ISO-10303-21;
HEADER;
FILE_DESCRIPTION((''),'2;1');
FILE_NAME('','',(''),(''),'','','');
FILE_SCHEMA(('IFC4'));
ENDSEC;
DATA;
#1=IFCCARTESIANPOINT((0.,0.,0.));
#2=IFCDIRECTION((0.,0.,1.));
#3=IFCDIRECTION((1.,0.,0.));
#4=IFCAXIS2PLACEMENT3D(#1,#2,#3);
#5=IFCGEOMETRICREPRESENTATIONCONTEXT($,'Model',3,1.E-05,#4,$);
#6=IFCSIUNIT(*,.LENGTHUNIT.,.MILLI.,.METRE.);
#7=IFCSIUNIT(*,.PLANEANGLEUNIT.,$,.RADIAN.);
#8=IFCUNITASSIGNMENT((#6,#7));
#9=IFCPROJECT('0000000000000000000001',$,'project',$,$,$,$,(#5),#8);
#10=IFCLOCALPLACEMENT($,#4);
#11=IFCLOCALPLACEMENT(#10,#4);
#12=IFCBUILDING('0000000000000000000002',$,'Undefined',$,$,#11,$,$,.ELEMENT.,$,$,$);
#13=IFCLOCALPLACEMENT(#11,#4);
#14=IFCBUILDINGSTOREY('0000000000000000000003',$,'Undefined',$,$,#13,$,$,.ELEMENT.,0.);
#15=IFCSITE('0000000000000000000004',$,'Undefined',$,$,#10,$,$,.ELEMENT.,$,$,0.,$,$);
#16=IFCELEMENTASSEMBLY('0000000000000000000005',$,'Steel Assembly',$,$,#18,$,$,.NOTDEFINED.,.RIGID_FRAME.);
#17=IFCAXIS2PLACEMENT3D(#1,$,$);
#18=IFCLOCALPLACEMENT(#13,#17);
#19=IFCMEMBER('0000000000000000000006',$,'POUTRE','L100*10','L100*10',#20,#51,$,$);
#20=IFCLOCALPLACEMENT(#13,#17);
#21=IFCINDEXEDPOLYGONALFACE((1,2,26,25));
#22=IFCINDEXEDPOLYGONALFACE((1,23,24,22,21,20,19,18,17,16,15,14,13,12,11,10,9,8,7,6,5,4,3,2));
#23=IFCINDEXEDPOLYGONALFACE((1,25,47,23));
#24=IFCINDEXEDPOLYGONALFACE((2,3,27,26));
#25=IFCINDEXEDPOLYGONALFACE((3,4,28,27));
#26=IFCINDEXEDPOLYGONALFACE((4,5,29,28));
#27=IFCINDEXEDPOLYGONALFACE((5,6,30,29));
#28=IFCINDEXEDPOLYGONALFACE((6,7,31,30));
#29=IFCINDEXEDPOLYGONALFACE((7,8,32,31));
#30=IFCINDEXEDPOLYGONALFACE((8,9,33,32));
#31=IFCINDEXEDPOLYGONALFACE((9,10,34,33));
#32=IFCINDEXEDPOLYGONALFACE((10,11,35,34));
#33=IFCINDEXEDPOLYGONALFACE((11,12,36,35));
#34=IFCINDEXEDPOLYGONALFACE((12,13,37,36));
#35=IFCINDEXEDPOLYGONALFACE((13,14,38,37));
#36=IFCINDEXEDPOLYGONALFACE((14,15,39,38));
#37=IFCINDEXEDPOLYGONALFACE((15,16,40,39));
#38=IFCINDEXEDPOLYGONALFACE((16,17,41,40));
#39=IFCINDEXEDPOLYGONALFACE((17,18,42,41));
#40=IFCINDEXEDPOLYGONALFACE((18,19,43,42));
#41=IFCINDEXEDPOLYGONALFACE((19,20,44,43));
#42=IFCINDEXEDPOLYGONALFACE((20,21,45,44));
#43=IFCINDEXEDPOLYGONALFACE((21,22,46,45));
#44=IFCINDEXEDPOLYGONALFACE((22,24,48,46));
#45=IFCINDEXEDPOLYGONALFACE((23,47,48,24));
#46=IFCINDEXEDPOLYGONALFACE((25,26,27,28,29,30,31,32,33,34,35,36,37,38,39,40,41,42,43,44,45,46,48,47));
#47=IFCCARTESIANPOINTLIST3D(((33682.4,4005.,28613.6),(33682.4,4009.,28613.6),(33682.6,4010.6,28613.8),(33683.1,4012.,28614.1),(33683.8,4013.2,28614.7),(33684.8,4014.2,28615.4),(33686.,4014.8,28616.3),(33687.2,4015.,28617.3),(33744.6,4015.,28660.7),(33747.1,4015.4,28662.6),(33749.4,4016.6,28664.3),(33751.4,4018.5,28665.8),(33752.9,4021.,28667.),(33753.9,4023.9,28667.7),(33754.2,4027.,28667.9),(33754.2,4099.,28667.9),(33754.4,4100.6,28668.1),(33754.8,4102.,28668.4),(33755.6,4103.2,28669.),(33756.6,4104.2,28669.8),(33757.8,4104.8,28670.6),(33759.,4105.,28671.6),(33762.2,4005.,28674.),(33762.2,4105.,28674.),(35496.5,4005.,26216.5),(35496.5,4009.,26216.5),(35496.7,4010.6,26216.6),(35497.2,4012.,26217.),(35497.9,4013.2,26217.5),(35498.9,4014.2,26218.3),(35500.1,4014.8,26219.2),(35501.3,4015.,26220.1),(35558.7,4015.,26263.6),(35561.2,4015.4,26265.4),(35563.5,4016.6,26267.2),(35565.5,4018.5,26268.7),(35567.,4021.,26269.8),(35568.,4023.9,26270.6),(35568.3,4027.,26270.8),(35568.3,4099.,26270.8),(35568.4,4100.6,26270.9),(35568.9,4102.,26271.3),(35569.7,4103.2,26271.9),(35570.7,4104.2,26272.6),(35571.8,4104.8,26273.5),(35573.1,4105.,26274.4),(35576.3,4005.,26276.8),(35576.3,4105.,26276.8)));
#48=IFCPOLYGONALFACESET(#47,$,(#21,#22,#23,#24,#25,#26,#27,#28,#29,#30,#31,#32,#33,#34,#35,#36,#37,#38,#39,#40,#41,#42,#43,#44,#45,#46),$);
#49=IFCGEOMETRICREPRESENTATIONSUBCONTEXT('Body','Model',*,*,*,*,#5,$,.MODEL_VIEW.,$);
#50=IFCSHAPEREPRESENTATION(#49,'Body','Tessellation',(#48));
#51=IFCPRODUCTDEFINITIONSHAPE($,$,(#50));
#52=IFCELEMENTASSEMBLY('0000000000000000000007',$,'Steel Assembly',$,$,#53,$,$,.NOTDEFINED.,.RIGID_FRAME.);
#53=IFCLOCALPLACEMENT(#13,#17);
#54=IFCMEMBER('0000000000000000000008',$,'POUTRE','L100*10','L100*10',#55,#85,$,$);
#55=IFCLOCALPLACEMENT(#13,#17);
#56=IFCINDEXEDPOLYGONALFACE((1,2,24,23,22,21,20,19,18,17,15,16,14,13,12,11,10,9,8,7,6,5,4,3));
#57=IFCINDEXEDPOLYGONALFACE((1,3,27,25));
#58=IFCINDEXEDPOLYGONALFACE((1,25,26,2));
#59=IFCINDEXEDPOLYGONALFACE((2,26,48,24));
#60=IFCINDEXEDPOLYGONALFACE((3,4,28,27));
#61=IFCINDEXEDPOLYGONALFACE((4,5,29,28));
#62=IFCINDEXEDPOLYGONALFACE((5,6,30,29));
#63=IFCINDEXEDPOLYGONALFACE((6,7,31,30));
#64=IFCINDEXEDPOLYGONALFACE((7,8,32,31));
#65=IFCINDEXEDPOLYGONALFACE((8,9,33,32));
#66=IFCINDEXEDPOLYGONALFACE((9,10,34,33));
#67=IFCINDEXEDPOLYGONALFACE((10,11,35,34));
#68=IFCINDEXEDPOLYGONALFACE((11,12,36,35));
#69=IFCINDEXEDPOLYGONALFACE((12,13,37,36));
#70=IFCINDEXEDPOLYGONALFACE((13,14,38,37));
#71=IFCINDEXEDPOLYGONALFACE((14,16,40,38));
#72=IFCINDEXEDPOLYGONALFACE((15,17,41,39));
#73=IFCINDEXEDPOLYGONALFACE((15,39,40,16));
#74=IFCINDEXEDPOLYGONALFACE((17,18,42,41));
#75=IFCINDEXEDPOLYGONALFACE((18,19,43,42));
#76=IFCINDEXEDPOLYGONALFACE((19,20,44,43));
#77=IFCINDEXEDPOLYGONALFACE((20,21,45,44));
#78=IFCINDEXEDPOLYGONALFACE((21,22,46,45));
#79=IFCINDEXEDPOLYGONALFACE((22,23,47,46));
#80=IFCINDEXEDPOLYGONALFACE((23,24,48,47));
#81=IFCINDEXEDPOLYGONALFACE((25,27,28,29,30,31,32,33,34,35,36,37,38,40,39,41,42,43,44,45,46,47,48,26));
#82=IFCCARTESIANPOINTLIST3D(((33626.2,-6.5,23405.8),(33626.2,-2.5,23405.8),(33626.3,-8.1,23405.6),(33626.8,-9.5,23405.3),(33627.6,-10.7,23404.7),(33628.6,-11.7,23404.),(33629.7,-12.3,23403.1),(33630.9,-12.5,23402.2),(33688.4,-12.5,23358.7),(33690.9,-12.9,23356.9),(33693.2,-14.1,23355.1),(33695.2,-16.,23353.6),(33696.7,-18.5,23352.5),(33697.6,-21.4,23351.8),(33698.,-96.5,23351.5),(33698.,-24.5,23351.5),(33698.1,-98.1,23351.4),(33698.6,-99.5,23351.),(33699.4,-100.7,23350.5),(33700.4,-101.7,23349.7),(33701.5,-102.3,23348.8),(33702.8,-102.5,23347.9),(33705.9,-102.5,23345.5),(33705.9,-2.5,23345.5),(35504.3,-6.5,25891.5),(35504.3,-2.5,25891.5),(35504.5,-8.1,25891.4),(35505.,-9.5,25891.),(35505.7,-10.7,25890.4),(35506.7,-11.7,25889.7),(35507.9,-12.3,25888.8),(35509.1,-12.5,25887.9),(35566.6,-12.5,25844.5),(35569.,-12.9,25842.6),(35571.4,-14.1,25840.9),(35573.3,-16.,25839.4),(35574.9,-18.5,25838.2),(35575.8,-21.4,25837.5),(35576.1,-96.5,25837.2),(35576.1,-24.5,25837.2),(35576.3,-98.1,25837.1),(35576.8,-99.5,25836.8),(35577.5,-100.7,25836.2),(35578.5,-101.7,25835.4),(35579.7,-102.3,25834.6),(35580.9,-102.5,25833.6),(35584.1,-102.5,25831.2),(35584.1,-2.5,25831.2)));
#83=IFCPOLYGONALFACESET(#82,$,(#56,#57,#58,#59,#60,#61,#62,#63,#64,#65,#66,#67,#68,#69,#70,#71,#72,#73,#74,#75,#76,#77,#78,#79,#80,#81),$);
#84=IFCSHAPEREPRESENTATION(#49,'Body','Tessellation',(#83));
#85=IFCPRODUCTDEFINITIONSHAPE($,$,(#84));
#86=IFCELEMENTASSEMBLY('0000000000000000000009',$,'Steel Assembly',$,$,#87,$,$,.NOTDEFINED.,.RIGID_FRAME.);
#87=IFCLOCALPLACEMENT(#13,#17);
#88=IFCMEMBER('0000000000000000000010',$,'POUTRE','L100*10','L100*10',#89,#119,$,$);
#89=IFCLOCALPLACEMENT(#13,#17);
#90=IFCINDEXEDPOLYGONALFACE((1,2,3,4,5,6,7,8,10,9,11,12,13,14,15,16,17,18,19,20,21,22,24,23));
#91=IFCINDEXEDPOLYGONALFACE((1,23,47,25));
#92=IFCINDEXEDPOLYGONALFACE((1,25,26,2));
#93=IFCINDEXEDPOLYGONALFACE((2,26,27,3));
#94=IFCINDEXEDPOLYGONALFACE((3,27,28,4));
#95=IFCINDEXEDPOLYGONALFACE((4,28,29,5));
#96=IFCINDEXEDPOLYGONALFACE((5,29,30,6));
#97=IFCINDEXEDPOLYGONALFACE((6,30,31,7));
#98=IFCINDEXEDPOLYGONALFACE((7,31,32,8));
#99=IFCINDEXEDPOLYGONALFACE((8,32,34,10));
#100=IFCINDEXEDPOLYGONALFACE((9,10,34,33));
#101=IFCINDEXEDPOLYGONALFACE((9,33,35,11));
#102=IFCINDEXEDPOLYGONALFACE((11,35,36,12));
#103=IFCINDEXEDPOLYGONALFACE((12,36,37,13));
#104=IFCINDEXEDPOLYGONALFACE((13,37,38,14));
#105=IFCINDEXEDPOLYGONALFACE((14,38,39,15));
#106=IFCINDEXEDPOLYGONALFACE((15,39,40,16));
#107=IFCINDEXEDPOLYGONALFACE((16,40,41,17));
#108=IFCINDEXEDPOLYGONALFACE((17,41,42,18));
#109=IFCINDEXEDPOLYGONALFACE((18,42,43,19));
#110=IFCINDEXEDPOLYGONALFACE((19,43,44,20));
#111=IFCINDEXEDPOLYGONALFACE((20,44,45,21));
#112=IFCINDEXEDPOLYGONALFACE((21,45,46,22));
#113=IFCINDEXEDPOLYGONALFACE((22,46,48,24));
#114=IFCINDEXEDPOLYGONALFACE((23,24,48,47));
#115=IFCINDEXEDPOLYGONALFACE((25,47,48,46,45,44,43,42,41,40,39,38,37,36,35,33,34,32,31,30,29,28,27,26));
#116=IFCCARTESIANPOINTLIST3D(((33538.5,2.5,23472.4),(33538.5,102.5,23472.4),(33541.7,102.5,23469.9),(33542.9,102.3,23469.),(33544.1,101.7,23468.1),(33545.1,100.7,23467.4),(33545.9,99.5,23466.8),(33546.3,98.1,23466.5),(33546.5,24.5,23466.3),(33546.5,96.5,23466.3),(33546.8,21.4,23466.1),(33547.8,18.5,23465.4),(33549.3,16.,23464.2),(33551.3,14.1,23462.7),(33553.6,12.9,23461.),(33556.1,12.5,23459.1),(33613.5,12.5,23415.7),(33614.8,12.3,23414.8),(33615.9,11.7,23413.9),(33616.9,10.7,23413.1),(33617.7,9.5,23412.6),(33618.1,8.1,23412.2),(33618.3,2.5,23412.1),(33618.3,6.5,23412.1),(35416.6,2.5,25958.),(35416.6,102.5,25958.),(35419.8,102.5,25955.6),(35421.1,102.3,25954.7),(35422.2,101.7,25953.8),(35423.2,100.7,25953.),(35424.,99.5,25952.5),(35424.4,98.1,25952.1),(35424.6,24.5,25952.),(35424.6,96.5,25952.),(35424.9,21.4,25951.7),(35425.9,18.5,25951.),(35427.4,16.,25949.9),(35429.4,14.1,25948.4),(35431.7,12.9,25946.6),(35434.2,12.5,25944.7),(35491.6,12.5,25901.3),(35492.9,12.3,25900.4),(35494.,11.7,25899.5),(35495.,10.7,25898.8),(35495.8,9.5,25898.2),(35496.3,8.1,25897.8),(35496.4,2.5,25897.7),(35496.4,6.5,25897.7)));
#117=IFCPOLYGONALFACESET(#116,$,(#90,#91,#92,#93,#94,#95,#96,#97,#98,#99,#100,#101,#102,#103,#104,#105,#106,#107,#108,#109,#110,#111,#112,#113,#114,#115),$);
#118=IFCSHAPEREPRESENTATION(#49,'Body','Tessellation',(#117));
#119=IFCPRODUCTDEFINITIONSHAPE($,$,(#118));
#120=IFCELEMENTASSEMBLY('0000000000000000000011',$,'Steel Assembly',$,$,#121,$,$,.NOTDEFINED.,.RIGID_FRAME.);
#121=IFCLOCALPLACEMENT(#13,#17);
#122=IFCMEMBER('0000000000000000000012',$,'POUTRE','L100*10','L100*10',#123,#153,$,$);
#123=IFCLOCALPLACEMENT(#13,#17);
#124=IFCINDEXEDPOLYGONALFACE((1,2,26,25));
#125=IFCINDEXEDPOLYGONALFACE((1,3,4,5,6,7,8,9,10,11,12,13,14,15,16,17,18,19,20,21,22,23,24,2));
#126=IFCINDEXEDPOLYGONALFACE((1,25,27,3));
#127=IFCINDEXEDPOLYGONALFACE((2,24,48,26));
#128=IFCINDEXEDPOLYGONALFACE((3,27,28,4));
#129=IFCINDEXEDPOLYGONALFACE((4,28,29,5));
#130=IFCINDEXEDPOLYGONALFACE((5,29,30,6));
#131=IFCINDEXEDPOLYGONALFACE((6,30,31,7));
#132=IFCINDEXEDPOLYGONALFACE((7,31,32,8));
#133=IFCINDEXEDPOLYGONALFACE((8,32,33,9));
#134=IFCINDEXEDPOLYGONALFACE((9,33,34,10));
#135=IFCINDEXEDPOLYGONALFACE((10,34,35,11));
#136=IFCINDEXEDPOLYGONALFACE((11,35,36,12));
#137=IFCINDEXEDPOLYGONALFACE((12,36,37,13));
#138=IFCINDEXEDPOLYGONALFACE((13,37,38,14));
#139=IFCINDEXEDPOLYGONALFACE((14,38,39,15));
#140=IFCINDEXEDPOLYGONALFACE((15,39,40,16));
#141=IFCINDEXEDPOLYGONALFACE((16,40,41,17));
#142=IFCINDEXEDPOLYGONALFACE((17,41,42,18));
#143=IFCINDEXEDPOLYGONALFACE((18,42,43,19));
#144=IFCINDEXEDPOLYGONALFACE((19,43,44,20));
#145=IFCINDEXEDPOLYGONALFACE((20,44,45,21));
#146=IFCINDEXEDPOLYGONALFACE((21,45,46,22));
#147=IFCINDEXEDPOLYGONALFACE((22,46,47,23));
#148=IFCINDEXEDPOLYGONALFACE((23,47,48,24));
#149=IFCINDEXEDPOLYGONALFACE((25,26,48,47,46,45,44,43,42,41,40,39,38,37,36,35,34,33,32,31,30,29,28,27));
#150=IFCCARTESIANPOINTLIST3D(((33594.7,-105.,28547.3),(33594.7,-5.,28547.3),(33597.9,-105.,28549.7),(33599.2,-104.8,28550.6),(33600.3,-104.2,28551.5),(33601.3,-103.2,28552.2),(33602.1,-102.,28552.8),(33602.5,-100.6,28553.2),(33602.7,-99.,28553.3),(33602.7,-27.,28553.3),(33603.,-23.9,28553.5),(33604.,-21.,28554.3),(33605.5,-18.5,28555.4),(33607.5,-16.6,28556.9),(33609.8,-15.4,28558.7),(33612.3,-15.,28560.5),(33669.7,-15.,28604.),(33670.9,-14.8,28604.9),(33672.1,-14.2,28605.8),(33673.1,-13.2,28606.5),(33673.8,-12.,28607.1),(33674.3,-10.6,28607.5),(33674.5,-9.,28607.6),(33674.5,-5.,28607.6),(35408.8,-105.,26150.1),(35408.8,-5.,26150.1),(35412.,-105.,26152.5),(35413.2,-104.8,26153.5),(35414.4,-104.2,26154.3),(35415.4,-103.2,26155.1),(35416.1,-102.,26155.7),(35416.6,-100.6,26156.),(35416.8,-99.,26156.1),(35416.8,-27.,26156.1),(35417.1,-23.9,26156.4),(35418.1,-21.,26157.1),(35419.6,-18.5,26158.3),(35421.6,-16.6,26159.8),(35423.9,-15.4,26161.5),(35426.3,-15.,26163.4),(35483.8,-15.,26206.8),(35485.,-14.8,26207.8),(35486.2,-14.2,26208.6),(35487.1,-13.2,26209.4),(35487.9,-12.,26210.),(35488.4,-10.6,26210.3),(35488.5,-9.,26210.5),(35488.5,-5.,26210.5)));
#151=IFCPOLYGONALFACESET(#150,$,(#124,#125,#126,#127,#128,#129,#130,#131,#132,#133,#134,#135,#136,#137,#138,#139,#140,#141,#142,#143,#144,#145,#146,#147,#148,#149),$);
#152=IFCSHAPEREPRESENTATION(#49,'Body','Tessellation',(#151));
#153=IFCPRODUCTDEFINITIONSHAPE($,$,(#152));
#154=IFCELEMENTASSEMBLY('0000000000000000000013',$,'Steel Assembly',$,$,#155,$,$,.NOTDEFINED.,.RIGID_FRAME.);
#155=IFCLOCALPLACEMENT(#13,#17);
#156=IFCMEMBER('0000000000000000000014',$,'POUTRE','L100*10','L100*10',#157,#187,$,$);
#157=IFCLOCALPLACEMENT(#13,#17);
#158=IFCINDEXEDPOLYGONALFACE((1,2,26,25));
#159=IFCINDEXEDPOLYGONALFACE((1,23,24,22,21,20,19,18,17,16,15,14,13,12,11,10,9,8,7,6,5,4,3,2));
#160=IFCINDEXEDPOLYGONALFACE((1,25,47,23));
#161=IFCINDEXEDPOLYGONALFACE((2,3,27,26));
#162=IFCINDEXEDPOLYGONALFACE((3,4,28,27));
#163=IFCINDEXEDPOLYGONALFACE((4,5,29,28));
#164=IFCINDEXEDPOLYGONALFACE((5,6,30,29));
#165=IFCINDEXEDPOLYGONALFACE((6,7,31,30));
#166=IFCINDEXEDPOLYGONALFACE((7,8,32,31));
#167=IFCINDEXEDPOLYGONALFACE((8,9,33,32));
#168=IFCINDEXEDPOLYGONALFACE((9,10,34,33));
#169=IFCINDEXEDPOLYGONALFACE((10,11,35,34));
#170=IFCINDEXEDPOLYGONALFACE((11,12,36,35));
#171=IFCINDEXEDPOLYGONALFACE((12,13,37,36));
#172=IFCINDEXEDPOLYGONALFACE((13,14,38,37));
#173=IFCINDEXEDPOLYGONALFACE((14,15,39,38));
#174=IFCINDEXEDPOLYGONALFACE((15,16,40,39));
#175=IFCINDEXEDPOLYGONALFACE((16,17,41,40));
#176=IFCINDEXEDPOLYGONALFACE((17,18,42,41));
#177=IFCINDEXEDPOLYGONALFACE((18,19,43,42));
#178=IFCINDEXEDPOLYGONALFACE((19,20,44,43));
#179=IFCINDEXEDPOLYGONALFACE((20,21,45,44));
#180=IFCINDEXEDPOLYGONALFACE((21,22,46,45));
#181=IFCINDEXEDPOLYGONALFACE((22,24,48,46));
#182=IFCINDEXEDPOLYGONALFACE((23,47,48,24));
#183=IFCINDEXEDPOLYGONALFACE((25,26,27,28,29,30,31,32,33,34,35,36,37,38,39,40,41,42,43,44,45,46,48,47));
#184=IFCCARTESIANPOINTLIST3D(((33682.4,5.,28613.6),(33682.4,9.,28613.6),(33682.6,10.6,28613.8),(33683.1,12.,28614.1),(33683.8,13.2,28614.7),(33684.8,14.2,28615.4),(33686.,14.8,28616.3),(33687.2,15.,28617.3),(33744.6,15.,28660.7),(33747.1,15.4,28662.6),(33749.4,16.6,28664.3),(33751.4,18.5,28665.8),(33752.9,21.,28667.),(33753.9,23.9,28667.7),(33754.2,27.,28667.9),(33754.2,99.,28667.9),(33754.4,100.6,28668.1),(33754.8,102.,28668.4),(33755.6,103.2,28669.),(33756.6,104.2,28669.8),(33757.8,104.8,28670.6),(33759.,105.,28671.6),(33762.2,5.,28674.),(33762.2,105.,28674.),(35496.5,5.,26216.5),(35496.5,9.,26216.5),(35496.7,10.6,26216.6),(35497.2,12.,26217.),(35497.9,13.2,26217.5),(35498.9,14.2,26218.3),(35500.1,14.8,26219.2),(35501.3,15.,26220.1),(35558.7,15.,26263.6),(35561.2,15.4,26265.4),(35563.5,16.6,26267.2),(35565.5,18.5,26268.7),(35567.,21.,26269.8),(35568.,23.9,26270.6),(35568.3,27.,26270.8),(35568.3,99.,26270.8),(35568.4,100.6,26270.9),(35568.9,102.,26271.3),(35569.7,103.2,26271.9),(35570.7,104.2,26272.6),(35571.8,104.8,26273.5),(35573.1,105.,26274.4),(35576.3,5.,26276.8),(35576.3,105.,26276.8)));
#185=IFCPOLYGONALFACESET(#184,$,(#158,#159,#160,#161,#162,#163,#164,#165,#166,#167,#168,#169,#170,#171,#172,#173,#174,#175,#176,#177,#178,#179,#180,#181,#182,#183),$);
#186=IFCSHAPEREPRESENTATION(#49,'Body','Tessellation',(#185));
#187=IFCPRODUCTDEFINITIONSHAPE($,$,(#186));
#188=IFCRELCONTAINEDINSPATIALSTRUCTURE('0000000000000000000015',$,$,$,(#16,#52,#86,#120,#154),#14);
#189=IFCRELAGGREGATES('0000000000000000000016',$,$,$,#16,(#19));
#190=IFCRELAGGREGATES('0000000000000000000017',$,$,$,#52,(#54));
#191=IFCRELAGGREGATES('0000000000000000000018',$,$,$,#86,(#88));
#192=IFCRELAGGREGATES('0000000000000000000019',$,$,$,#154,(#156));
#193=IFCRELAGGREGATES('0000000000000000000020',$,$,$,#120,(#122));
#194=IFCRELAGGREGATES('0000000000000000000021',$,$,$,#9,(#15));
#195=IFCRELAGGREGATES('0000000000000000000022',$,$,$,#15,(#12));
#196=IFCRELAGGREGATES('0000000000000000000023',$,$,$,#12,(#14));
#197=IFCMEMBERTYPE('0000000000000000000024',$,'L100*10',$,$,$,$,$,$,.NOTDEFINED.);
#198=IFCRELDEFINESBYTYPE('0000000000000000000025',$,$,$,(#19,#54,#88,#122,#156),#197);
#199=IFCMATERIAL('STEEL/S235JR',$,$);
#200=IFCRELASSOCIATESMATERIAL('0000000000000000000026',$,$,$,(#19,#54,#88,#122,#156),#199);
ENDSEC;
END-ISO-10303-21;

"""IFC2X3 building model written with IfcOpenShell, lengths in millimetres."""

from ifc_helpers import new_model, si_unit, frame, origin_with_axes, origin_2d_with_axis, place, context, subcontext, project, spatial, l_section, extrude, clip, halfspace, material, type_object, element, aggregate, save


model = new_model("IFC2X3")

# Units and contexts
model_context = context("Model", 3, precision=1e-05, world=origin_with_axes())
body_context = subcontext(model_context, "Body", "Model", "MODEL_VIEW")
ifc_project = project(units=[si_unit("LENGTHUNIT", "METRE", prefix="MILLI"), si_unit("PLANEANGLEUNIT", "RADIAN")], contexts=[model_context])

# Site, building, storey
site_placement = place(None, origin_with_axes())
site = spatial("IfcSite", under=ifc_project, at=site_placement, Name="Undefined", CompositionType="ELEMENT", RefElevation=0.0)
building_placement = place(site_placement, origin_with_axes())
building = spatial("IfcBuilding", under=site, at=building_placement, Name="Undefined", CompositionType="ELEMENT")
storey_placement = place(building_placement, origin_with_axes())
storey = spatial("IfcBuildingStorey", under=building, at=storey_placement, Name="Undefined", CompositionType="ELEMENT", Elevation=0.0)

# Shared definitions
ifc_material_1 = material(Name="STEEL/S235JR")

# Element assemblies, members
member_type = type_object("IfcMemberType", Name="L100*10", PredefinedType="NOTDEFINED")
assembly_1_placement = place(storey_placement, origin_with_axes())
assembly_1 = element("IfcElementAssembly", 1, at=assembly_1_placement, inside=storey, Name="Steel Assembly", AssemblyPlace="NOTDEFINED", PredefinedType="RIGID_FRAME")
member_1_placement = place(assembly_1_placement, frame((33722.3, 4055.0, 28643.8), z_axis=(-0.797403, 0.0, -0.603447), x_axis=(0.603447, 0.0, -0.797403)))
member_1 = element("IfcMember", 2, at=member_1_placement, type_object=member_type, material=ifc_material_1, Name="POUTRE", Description="L100*10", ObjectType="L100*10", context=body_context, shape_type="Clipping", body=[
    clip(extrude(l_section(Depth=100.0, Width=100.0, Thickness=10.0, FilletRadius=12.0, EdgeRadius=6.0, at=origin_2d_with_axis()), frame((6780.5, 0.0, 0.0), z_axis=(-1.0, 0.0, 0.0), x_axis=(0.0, -1.0, 0.0)), (0.0, 0.0, 1.0), 6780.5), halfspace(frame((3006.1, 50.0, -50.0), z_axis=(1.0, 0.0, 0.0), x_axis=(0.0, -1.0, 0.0)), False)),
])
aggregate(assembly_1, [member_1])
assembly_2_placement = place(storey_placement, origin_with_axes())
assembly_2 = element("IfcElementAssembly", 3, at=assembly_2_placement, inside=storey, Name="Steel Assembly", AssemblyPlace="NOTDEFINED", PredefinedType="RIGID_FRAME")
member_2_placement = place(assembly_2_placement, frame((33666.0, -52.5, 23375.6), z_axis=(-0.797857, 0.0, 0.602847), x_axis=(0.602847, 0.0, 0.797857)))
member_2 = element("IfcMember", 4, at=member_2_placement, type_object=member_type, material=ifc_material_1, Name="POUTRE", Description="L100*10", ObjectType="L100*10", context=body_context, shape_type="SweptSolid", body=[
    extrude(l_section(Depth=100.0, Width=100.0, Thickness=10.0, FilletRadius=12.0, EdgeRadius=6.0, at=origin_2d_with_axis()), frame((3115.5, 0.0, 0.0), z_axis=(-1.0, 0.0, 0.0), x_axis=(0.0, -1.0, 0.0)), (0.0, 0.0, 1.0), 3115.5),
])
aggregate(assembly_2, [member_2])
assembly_3_placement = place(storey_placement, origin_with_axes())
assembly_3 = element("IfcElementAssembly", 5, at=assembly_3_placement, inside=storey, Name="Steel Assembly", AssemblyPlace="NOTDEFINED", PredefinedType="RIGID_FRAME")
member_3_placement = place(assembly_3_placement, frame((33578.4, 52.5, 23442.2), z_axis=(0.797856, 0.0, -0.602848), x_axis=(0.602847, 0.0, 0.797857)))
member_3 = element("IfcMember", 6, at=member_3_placement, type_object=member_type, material=ifc_material_1, Name="POUTRE", Description="L100*10", ObjectType="L100*10", context=body_context, shape_type="SweptSolid", body=[
    extrude(l_section(Depth=100.0, Width=100.0, Thickness=10.0, FilletRadius=12.0, EdgeRadius=6.0, at=origin_2d_with_axis()), frame((3115.4, 0.0, 0.0), z_axis=(-1.0, 0.0, 0.0), x_axis=(0.0, -1.0, 0.0)), (0.0, 0.0, 1.0), 3115.4),
])
aggregate(assembly_3, [member_3])
assembly_4_placement = place(storey_placement, origin_with_axes())
assembly_4 = element("IfcElementAssembly", 7, at=assembly_4_placement, inside=storey, Name="Steel Assembly", AssemblyPlace="NOTDEFINED", PredefinedType="RIGID_FRAME")
member_4_placement = place(assembly_4_placement, frame((33634.6, -55.0, 28577.4), z_axis=(0.797403, 0.0, 0.603447), x_axis=(0.603447, 0.0, -0.797403)))
member_4 = element("IfcMember", 8, at=member_4_placement, type_object=member_type, material=ifc_material_1, Name="POUTRE", Description="L100*10", ObjectType="L100*10", context=body_context, shape_type="Clipping", body=[
    clip(extrude(l_section(Depth=100.0, Width=100.0, Thickness=10.0, FilletRadius=12.0, EdgeRadius=6.0, at=origin_2d_with_axis()), frame((6780.5, 0.0, 0.0), z_axis=(-1.0, 0.0, 0.0), x_axis=(0.0, -1.0, 0.0)), (0.0, 0.0, 1.0), 6780.5), halfspace(frame((3006.1, -50.0, 50.0), z_axis=(1.0, 0.0, 0.0), x_axis=(0.0, 1.0, 0.0)), False)),
])
assembly_5_placement = place(storey_placement, origin_with_axes())
assembly_5 = element("IfcElementAssembly", 9, at=assembly_5_placement, inside=storey, Name="Steel Assembly", AssemblyPlace="NOTDEFINED", PredefinedType="RIGID_FRAME")
member_5_placement = place(assembly_5_placement, frame((33722.3, 55.0, 28643.8), z_axis=(-0.797403, 0.0, -0.603447), x_axis=(0.603447, 0.0, -0.797403)))
member_5 = element("IfcMember", 10, at=member_5_placement, type_object=member_type, material=ifc_material_1, Name="POUTRE", Description="L100*10", ObjectType="L100*10", context=body_context, shape_type="Clipping", body=[
    clip(extrude(l_section(Depth=100.0, Width=100.0, Thickness=10.0, FilletRadius=12.0, EdgeRadius=6.0, at=origin_2d_with_axis()), frame((6780.5, 0.0, 0.0), z_axis=(-1.0, 0.0, 0.0), x_axis=(0.0, -1.0, 0.0)), (0.0, 0.0, 1.0), 6780.5), halfspace(frame((3006.1, 50.0, -50.0), z_axis=(1.0, 0.0, 0.0), x_axis=(0.0, -1.0, 0.0)), False)),
])
aggregate(assembly_5, [member_5])

aggregate(assembly_4, [member_4])

save(model, "model.ifc")
